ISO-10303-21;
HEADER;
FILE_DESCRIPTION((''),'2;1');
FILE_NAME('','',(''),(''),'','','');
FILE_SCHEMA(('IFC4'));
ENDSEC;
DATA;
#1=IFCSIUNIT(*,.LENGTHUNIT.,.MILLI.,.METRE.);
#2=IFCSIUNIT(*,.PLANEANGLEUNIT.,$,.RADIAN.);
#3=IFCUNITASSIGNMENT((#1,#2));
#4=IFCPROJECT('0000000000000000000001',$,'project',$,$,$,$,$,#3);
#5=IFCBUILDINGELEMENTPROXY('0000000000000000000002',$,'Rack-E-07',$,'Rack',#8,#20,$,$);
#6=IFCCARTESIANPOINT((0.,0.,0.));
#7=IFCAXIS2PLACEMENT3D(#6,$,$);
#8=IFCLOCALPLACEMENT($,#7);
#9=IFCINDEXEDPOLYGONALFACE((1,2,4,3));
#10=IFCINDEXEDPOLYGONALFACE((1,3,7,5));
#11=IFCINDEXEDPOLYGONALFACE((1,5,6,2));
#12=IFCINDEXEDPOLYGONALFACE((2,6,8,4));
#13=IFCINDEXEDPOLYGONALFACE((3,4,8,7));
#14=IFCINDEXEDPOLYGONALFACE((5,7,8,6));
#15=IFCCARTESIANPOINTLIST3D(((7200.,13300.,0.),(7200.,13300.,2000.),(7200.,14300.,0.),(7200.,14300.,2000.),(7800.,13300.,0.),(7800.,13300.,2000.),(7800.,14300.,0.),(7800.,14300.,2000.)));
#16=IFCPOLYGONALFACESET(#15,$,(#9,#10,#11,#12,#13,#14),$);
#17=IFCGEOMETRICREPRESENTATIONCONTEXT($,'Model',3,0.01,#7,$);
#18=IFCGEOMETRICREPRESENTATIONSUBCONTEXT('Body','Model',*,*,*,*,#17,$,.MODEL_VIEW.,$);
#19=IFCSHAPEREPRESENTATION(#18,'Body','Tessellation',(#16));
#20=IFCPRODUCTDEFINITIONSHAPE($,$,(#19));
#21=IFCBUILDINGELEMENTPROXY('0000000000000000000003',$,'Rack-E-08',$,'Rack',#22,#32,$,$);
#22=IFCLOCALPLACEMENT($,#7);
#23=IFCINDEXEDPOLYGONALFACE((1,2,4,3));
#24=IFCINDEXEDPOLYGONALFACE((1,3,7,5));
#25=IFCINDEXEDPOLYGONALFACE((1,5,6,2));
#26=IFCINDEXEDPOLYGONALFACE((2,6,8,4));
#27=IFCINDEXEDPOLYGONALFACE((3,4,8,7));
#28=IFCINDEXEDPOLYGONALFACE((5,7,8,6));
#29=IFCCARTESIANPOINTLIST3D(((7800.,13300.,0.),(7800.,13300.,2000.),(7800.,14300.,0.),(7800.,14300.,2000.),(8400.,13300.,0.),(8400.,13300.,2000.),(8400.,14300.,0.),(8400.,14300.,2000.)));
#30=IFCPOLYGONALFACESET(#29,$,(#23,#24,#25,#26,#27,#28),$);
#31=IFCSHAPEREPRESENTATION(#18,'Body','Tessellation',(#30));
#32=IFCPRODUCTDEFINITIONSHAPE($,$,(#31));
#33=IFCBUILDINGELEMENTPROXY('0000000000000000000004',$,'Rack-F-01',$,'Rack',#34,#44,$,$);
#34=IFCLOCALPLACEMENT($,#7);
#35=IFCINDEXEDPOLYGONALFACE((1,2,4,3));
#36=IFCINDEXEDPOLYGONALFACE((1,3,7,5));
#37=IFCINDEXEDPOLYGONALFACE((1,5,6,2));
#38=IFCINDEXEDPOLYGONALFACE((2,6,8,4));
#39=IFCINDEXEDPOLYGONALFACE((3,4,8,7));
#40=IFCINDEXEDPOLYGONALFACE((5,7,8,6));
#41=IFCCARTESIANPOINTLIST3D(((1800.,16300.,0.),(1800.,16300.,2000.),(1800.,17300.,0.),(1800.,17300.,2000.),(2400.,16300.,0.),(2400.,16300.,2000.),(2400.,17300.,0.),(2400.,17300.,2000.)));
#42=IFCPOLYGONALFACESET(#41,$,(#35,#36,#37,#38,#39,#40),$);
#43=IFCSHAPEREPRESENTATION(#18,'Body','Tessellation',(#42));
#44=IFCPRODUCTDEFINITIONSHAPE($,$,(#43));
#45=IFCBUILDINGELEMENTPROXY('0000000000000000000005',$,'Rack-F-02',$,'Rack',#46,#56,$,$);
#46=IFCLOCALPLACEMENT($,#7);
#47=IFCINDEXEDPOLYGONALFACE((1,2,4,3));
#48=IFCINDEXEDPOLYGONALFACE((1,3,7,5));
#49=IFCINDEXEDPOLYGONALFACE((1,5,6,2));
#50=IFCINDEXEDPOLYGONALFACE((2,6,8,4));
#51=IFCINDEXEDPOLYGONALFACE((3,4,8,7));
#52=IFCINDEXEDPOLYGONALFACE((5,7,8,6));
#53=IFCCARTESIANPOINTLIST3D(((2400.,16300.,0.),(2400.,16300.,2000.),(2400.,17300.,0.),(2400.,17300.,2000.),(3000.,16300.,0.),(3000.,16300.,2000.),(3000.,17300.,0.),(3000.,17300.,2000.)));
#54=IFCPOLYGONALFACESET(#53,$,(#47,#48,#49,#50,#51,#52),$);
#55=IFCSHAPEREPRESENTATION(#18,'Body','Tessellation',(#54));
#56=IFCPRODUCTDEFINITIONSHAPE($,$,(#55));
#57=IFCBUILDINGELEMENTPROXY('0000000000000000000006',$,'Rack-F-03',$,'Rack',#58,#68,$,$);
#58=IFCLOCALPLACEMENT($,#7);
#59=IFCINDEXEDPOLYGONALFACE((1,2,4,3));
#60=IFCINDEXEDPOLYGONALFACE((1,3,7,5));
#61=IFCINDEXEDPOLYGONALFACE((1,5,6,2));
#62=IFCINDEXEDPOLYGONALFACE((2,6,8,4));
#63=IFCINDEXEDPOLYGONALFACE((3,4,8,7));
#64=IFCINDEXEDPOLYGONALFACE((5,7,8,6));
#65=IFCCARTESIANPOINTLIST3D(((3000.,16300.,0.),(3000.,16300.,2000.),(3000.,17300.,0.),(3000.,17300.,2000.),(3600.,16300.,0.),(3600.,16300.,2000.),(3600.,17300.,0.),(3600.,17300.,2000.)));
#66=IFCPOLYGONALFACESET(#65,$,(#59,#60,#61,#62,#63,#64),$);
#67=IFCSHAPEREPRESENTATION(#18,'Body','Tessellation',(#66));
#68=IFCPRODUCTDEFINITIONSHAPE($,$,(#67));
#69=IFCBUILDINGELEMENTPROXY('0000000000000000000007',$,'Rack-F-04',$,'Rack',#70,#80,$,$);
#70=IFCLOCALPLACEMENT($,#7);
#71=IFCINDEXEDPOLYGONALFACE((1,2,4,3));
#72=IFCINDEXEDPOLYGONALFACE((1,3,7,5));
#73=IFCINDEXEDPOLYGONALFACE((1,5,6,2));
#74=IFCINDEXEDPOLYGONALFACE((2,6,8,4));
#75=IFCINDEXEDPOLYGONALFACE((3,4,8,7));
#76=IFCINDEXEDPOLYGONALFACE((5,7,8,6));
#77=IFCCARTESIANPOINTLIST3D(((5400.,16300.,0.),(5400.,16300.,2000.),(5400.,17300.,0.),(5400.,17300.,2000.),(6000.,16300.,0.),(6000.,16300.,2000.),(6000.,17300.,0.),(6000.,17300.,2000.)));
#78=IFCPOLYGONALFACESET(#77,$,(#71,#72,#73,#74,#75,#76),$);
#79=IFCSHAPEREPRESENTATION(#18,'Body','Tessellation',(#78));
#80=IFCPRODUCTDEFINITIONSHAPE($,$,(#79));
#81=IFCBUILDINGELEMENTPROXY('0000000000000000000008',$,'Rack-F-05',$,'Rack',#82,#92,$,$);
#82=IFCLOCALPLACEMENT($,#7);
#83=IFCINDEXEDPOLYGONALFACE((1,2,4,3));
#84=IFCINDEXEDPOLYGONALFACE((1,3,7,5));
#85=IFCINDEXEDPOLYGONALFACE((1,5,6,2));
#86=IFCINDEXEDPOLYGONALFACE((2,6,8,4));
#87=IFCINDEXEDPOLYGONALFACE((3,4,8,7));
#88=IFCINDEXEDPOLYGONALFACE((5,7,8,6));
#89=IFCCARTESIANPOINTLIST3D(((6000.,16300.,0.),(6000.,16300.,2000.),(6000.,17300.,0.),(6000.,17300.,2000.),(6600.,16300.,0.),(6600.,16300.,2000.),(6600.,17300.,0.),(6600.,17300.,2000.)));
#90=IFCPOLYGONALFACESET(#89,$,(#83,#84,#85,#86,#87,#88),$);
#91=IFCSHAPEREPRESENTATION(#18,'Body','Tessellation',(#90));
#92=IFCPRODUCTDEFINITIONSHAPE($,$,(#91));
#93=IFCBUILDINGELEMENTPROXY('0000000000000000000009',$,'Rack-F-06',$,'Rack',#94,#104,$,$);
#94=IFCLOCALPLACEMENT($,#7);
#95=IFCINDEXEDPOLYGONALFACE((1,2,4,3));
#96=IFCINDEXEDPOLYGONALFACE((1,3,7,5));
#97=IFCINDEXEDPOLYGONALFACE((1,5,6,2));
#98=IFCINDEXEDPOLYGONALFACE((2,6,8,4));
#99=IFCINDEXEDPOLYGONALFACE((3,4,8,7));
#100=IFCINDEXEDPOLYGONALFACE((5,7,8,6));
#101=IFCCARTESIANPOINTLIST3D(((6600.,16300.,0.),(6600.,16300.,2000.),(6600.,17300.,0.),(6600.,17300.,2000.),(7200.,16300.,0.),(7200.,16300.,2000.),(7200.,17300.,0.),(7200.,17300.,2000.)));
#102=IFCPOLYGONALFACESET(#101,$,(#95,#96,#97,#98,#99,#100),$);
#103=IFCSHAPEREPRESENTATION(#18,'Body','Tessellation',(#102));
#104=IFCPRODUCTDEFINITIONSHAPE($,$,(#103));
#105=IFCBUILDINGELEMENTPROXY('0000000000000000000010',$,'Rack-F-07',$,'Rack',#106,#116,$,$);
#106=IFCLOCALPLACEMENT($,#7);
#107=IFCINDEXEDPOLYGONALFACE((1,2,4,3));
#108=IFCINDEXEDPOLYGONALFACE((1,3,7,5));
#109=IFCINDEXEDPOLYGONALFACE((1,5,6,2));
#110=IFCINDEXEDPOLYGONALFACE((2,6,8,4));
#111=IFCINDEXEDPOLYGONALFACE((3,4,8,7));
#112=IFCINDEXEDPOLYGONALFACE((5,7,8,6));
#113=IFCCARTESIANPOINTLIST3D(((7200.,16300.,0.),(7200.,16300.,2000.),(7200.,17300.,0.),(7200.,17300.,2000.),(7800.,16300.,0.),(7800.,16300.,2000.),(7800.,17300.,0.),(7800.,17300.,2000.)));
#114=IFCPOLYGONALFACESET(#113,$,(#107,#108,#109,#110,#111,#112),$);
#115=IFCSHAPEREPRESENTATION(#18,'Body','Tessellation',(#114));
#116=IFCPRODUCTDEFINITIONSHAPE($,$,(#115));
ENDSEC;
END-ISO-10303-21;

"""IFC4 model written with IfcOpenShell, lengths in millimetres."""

from ifc_helpers import new_model, si_unit, frame, origin, place, context, subcontext, project, rectangle, extrude, element, save


model = new_model("IFC4")

# Units and contexts
model_context = context("Model", 3, precision=0.01, world=origin())
body_context = subcontext(model_context, "Body", "Model", "MODEL_VIEW")
ifc_project = project(units=[si_unit("LENGTHUNIT", "METRE", prefix="MILLI"), si_unit("PLANEANGLEUNIT", "RADIAN")])

# Shared definitions
placement = place(None, origin())

# Building element proxies
for number, where, name in (
    (1, (7500.0, 13800.0, 0.0), "Rack-E-07"),
    (2, (8100.0, 13800.0, 0.0), "Rack-E-08"),
    (3, (2100.0, 16800.0, 0.0), "Rack-F-01"),
    (4, (2700.0, 16800.0, 0.0), "Rack-F-02"),
    (5, (3300.0, 16800.0, 0.0), "Rack-F-03"),
    (6, (5700.0, 16800.0, 0.0), "Rack-F-04"),
    (7, (6300.0, 16800.0, 0.0), "Rack-F-05"),
    (8, (6900.0, 16800.0, 0.0), "Rack-F-06"),
    (9, (7500.0, 16800.0, 0.0), "Rack-F-07"),
):
    element("IfcBuildingElementProxy", number, at=place(placement, frame(where)), Name=name, ObjectType="Rack", context=body_context, shape_type="SweptSolid", body=[
        extrude(rectangle(XDim=600.0, YDim=1000.0), origin(), (0.0, 0.0, 1.0), 2000.0),
    ])

save(model, "model.ifc")
